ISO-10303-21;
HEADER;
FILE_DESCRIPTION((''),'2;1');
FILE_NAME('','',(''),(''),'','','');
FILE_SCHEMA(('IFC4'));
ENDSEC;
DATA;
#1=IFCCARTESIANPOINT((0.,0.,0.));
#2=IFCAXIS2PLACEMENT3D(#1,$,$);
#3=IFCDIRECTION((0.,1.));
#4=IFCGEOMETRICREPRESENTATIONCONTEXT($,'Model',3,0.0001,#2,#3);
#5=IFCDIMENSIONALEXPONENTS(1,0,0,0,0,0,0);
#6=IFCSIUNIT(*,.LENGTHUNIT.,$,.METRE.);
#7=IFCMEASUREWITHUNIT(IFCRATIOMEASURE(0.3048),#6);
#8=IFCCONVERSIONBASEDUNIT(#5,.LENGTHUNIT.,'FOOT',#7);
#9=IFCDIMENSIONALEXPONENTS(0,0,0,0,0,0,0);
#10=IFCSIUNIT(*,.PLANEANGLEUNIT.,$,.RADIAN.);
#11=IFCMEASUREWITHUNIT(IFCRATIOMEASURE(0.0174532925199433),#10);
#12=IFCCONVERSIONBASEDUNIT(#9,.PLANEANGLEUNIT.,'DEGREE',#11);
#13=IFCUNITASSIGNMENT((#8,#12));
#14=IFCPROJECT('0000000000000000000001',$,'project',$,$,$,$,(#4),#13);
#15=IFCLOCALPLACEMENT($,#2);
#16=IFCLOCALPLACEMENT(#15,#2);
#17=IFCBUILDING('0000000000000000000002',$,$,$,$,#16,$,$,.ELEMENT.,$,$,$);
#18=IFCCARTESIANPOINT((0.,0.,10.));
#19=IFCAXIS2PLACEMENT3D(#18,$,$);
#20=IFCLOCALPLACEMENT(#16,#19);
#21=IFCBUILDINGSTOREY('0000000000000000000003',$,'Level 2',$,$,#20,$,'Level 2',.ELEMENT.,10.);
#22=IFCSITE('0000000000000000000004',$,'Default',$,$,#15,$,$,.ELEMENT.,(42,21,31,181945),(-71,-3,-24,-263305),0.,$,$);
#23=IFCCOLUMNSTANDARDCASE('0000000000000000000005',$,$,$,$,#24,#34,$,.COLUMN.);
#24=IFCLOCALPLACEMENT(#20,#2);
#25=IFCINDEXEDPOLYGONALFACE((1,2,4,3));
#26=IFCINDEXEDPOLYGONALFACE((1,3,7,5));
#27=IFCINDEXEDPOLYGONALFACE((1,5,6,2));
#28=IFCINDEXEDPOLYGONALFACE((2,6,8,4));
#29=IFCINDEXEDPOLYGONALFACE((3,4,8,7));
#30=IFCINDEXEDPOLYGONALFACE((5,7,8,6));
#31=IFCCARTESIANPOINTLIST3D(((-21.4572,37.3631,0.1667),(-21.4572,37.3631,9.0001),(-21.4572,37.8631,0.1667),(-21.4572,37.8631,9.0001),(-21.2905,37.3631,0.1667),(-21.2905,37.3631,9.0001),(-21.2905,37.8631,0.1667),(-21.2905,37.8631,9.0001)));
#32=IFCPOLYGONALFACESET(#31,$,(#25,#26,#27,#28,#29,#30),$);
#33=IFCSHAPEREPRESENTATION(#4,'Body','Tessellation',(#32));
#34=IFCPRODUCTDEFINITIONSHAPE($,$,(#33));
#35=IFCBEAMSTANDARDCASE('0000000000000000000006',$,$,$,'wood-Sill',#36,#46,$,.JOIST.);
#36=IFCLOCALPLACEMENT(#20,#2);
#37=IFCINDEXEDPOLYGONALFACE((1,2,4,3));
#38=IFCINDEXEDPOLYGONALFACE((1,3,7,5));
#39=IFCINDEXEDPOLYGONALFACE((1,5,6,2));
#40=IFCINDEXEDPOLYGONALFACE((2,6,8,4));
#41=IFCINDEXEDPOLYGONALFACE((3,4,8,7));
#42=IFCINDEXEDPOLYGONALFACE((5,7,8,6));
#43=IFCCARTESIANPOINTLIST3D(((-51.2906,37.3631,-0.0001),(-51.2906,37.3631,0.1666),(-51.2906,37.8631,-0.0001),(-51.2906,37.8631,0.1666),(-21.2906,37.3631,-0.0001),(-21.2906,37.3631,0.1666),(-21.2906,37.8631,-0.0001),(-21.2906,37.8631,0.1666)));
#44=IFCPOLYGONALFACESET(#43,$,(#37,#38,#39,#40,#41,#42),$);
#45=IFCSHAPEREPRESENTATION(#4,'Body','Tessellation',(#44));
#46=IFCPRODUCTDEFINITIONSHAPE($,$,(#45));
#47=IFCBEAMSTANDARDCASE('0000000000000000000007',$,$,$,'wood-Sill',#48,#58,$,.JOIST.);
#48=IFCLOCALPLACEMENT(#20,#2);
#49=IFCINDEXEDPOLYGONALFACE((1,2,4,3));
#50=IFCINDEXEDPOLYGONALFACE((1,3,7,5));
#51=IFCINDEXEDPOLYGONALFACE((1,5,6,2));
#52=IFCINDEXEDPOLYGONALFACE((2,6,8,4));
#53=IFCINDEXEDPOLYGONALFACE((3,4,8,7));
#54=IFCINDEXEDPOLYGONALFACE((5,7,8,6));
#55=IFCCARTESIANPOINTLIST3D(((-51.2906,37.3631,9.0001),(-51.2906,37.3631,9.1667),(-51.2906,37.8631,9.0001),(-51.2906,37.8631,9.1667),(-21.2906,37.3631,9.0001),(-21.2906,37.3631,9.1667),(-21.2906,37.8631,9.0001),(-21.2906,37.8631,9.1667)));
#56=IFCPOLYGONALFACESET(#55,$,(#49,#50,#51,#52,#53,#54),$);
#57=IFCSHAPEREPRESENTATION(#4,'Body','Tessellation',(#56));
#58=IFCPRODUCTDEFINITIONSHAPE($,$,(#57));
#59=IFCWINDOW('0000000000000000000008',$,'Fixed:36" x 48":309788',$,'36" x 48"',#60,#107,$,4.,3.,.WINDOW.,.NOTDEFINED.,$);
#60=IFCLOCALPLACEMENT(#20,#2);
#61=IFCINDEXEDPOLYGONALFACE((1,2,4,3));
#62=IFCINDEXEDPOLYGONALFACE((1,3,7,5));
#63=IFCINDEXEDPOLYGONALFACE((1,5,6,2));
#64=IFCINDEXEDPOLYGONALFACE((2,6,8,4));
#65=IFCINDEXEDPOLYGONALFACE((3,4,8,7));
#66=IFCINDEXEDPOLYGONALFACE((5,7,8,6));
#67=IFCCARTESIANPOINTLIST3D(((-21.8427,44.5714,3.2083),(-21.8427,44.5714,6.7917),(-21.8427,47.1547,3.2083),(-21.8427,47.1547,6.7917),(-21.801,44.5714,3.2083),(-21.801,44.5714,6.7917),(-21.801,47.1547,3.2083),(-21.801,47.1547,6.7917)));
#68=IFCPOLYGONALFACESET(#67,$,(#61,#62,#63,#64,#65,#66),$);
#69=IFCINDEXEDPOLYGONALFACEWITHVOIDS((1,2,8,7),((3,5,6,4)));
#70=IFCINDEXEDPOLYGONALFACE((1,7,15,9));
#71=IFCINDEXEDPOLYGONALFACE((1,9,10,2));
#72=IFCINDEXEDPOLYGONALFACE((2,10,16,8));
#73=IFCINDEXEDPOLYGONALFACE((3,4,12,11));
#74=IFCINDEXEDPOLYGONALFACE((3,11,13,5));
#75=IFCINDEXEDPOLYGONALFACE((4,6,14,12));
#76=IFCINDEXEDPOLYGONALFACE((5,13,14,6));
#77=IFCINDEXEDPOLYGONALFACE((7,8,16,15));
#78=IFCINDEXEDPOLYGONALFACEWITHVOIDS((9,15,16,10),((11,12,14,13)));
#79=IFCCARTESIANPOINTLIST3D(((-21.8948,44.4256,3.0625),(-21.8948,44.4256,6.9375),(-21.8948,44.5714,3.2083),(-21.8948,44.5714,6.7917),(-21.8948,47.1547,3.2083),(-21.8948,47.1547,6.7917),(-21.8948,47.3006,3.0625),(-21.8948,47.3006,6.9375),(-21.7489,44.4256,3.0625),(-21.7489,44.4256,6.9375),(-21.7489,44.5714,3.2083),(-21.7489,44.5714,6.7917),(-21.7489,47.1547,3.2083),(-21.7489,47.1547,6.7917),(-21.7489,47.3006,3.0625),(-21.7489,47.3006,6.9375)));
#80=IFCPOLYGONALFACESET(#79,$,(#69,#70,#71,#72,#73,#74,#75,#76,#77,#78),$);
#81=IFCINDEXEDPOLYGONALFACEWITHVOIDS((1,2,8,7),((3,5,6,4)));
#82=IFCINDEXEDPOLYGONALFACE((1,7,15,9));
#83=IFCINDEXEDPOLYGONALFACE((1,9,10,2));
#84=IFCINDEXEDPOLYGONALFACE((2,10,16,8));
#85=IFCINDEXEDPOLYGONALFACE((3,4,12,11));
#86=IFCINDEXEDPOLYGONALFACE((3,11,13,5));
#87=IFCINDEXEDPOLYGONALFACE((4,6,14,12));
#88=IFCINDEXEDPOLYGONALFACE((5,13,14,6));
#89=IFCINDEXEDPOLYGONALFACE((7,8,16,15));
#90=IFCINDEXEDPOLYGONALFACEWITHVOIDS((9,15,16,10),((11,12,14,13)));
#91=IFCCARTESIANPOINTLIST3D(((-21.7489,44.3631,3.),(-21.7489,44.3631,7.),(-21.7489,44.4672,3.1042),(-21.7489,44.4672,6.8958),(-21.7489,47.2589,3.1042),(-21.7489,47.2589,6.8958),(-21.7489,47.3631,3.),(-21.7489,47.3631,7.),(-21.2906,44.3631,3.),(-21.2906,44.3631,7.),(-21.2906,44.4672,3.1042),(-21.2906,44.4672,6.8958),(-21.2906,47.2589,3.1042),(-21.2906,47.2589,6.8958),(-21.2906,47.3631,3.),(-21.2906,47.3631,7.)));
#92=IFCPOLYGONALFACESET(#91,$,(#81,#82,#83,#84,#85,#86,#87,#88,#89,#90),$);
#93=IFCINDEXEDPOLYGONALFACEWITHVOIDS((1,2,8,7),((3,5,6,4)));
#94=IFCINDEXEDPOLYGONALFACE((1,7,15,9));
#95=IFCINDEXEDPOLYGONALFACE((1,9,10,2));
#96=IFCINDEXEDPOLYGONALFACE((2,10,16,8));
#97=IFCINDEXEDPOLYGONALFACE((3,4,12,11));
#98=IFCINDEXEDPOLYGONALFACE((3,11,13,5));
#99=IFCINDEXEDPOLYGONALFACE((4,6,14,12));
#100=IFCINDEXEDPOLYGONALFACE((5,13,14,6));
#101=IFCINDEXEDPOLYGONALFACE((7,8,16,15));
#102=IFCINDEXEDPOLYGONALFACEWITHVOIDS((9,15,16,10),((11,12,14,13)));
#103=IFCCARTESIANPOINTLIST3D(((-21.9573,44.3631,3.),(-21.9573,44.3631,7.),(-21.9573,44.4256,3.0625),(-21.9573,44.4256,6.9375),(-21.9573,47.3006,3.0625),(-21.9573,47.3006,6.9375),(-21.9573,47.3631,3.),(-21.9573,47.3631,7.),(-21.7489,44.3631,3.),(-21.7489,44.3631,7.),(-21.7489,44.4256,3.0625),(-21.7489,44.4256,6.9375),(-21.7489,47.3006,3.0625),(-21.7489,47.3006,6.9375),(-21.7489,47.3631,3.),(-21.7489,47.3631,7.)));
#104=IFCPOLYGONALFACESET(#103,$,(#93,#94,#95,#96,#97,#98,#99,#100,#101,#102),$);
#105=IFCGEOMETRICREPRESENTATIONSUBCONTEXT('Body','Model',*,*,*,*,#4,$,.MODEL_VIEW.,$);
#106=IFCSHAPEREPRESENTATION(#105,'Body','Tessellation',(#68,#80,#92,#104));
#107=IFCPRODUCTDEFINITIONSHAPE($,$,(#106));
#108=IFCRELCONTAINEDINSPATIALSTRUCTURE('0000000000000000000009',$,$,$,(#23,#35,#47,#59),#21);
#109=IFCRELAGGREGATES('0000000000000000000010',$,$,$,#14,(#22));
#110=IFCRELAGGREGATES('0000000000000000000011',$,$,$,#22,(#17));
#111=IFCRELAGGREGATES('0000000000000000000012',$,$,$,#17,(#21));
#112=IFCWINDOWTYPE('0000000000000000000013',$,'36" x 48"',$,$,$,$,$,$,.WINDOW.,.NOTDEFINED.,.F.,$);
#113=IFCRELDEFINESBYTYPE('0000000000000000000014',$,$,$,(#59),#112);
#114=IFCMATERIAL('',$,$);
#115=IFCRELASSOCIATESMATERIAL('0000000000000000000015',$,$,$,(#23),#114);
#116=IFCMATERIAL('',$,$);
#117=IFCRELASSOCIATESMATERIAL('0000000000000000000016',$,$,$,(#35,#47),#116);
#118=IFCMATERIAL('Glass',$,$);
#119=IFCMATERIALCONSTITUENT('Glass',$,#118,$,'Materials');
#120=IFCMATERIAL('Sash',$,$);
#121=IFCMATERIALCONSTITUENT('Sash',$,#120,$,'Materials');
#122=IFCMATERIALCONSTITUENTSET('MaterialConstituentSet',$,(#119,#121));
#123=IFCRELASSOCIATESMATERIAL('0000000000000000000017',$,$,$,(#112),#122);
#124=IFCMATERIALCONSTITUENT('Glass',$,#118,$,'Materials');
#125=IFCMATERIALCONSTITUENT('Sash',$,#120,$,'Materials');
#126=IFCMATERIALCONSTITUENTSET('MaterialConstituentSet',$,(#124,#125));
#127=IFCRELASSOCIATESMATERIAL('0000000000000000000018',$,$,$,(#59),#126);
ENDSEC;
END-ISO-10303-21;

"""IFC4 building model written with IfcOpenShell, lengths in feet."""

from ifc_helpers import new_model, entity, si_unit, converted_unit, direction, frame, frame_2d, origin, origin_with_axes, place, context, subcontext, project, spatial, polyline, rectangle, outline, extrude, source, transform, mapped, material, constituent, constituent_set, type_object, type_shapes, element, save


model = new_model("IFC4")

# Units and contexts
model_context = context("Model", 3, precision=0.0001, world=origin(), true_north=direction((0.0, 1.0)))
body_context = subcontext(model_context, "Body", "Model", "MODEL_VIEW")
ifc_project = project(units=[converted_unit("LENGTHUNIT", "FOOT", entity("IfcRatioMeasure", 0.3048), si_unit("LENGTHUNIT", "METRE"), dimensions=[1, 0, 0, 0, 0, 0, 0]), converted_unit("PLANEANGLEUNIT", "DEGREE", entity("IfcRatioMeasure", 0.0174532925199433), si_unit("PLANEANGLEUNIT", "RADIAN"), dimensions=[0, 0, 0, 0, 0, 0, 0])], contexts=[model_context])

# Site, building, storey
site_placement = place(None, origin())
site = spatial("IfcSite", under=ifc_project, at=site_placement, Name="Default", CompositionType="ELEMENT", RefLatitude=(42, 21, 31, 181945), RefLongitude=(-71, -3, -24, -263305), RefElevation=0.0)
building_placement = place(site_placement, origin())
building = spatial("IfcBuilding", under=site, at=building_placement, CompositionType="ELEMENT")
storey_placement = place(building_placement, frame((0.0, 0.0, 10.0)))
storey = spatial("IfcBuildingStorey", under=building, at=storey_placement, Name="Level 2", LongName="Level 2", CompositionType="ELEMENT", Elevation=10.0)

# Column
ifc_material_1 = material(Name="")
placement_1 = place(storey_placement, frame((-21.2906, 37.6131, 0.0), z_axis=(0.0, 0.0, 1.0), x_axis=(-1.0, 0.0, 0.0)))
column_placement = place(placement_1, frame((0.0833, 0.0, 0.1667), z_axis=(0.0, 0.0, 1.0), x_axis=(1.0, 0.0, 0.0)))
element("IfcColumnStandardCase", 1, at=column_placement, inside=storey, material=ifc_material_1, PredefinedType="COLUMN", context=model_context, shape_type="SweptSolid", body=[
    extrude(rectangle(XDim=0.1667, YDim=0.5), origin(), (0.0, 0.0, 1.0), 8.8334),
])
placement_2 = place(storey_placement, frame((-21.6239, 54.4464, 0.0), z_axis=(0.0, 0.0, 1.0), x_axis=(0.0, -1.0, 0.0)))

# Beams
ifc_material_2 = material(Name="")
for number, where, z_axis, x_axis in (
    (2, (0.0, 0.0, 0.0833), (1.0, 0.0, 0.0), (0.0, 0.0, 1.0)),
    (3, (0.0, 0.0, 9.0834), (1.0, 0.0, 0.0), (0.0, 0.0, 1.0)),
):
    element("IfcBeamStandardCase", number, at=place(placement_1, frame(where, z_axis=z_axis, x_axis=x_axis)), inside=storey, material=ifc_material_2, ObjectType="wood-Sill", PredefinedType="JOIST", context=model_context, shape_type="SweptSolid", body=[
        extrude(rectangle(XDim=0.1667, YDim=0.5), origin_with_axes(), (0.0, 0.0, 1.0), 30.0),
    ])

# Window
ifc_material_3 = material(Name="Glass")
ifc_constituent_1 = constituent(ifc_material_3, Name="Glass", Category="Materials")
ifc_material_4 = material(Name="Sash")
ifc_constituent_2 = constituent(ifc_material_4, Name="Sash", Category="Materials")
ifc_constituent_set_1 = constituent_set(constituents=[ifc_constituent_1, ifc_constituent_2], Name="MaterialConstituentSet")
ifc_constituent_3 = constituent(ifc_material_3, Name="Glass", Category="Materials")
ifc_constituent_4 = constituent(ifc_material_4, Name="Sash", Category="Materials")
ifc_constituent_set_2 = constituent_set(constituents=[ifc_constituent_3, ifc_constituent_4], Name="MaterialConstituentSet")
window_type = type_object("IfcWindowType", Name="36\" x 48\"", ParameterTakesPrecedence=False, PartitioningType="NOTDEFINED", PredefinedType="WINDOW", material=ifc_constituent_set_2)
shared_shape = source(origin(), body_context, "Body", "SweptSolid", [
    extrude(rectangle(XDim=0.0417, YDim=2.5833, at=frame_2d((0.0, 0.0), x_axis=(1.0, 0.0))), frame((1.5, 0.5312, 0.2083), z_axis=(0.0, 0.0, 1.0), x_axis=(0.0, 1.0, 0.0)), (0.0, 0.0, 1.0), 3.5833),
    extrude(outline(polyline([(-1.4375, -1.9375), (1.4375, -1.9375), (1.4375, 1.9375), (-1.4375, 1.9375), (-1.4375, -1.9375)]), holes=[polyline([(-1.2917, -1.7917), (-1.2917, 1.7917), (1.2917, 1.7917), (1.2917, -1.7917), (-1.2917, -1.7917)])]), frame((1.5, 0.4583, 2.0), z_axis=(0.0, 1.0, 0.0), x_axis=(1.0, 0.0, 0.0)), (0.0, 0.0, 1.0), 0.1458),
    extrude(outline(polyline([(-1.5, -2.0), (1.5, -2.0), (1.5, 2.0), (-1.5, 2.0), (-1.5, -2.0)]), holes=[polyline([(-1.3958, -1.8958), (-1.3958, 1.8958), (1.3958, 1.8958), (1.3958, -1.8958), (-1.3958, -1.8958)])]), frame((1.5, 0.0, 2.0), z_axis=(0.0, 1.0, 0.0), x_axis=(1.0, 0.0, 0.0)), (0.0, 0.0, 1.0), 0.4583),
    extrude(outline(polyline([(-2.0, -1.5), (2.0, -1.5), (2.0, 1.5), (-2.0, 1.5), (-2.0, -1.5)]), holes=[polyline([(-1.9375, -1.4375), (-1.9375, 1.4375), (1.9375, 1.4375), (1.9375, -1.4375), (-1.9375, -1.4375)])]), frame((1.5, 0.4583, 2.0), z_axis=(0.0, 1.0, 0.0), x_axis=(0.0, 0.0, -1.0)), (0.0, 0.0, 1.0), 0.2083),
])
type_shapes(window_type, [shared_shape])
placement_3 = place(placement_2, frame((10.0833, 0.3333, 3.0)))
window_placement = place(placement_3, frame((0.0, 0.0, 0.0), z_axis=(0.0, 0.0, 1.0), x_axis=(-1.0, 0.0, 0.0)))
element("IfcWindow", 4, at=window_placement, inside=storey, type_object=window_type, material=ifc_constituent_set_1, Name="Fixed:36\" x 48\":309788", ObjectType="36\" x 48\"", OverallHeight=4.0, OverallWidth=3.0, PartitioningType="NOTDEFINED", PredefinedType="WINDOW", context=body_context, shape_type="MappedRepresentation", body=[
    mapped(shared_shape, transform((0.0, 0.0, 0.0), scale=1.0)),
])

save(model, "model.ifc")
